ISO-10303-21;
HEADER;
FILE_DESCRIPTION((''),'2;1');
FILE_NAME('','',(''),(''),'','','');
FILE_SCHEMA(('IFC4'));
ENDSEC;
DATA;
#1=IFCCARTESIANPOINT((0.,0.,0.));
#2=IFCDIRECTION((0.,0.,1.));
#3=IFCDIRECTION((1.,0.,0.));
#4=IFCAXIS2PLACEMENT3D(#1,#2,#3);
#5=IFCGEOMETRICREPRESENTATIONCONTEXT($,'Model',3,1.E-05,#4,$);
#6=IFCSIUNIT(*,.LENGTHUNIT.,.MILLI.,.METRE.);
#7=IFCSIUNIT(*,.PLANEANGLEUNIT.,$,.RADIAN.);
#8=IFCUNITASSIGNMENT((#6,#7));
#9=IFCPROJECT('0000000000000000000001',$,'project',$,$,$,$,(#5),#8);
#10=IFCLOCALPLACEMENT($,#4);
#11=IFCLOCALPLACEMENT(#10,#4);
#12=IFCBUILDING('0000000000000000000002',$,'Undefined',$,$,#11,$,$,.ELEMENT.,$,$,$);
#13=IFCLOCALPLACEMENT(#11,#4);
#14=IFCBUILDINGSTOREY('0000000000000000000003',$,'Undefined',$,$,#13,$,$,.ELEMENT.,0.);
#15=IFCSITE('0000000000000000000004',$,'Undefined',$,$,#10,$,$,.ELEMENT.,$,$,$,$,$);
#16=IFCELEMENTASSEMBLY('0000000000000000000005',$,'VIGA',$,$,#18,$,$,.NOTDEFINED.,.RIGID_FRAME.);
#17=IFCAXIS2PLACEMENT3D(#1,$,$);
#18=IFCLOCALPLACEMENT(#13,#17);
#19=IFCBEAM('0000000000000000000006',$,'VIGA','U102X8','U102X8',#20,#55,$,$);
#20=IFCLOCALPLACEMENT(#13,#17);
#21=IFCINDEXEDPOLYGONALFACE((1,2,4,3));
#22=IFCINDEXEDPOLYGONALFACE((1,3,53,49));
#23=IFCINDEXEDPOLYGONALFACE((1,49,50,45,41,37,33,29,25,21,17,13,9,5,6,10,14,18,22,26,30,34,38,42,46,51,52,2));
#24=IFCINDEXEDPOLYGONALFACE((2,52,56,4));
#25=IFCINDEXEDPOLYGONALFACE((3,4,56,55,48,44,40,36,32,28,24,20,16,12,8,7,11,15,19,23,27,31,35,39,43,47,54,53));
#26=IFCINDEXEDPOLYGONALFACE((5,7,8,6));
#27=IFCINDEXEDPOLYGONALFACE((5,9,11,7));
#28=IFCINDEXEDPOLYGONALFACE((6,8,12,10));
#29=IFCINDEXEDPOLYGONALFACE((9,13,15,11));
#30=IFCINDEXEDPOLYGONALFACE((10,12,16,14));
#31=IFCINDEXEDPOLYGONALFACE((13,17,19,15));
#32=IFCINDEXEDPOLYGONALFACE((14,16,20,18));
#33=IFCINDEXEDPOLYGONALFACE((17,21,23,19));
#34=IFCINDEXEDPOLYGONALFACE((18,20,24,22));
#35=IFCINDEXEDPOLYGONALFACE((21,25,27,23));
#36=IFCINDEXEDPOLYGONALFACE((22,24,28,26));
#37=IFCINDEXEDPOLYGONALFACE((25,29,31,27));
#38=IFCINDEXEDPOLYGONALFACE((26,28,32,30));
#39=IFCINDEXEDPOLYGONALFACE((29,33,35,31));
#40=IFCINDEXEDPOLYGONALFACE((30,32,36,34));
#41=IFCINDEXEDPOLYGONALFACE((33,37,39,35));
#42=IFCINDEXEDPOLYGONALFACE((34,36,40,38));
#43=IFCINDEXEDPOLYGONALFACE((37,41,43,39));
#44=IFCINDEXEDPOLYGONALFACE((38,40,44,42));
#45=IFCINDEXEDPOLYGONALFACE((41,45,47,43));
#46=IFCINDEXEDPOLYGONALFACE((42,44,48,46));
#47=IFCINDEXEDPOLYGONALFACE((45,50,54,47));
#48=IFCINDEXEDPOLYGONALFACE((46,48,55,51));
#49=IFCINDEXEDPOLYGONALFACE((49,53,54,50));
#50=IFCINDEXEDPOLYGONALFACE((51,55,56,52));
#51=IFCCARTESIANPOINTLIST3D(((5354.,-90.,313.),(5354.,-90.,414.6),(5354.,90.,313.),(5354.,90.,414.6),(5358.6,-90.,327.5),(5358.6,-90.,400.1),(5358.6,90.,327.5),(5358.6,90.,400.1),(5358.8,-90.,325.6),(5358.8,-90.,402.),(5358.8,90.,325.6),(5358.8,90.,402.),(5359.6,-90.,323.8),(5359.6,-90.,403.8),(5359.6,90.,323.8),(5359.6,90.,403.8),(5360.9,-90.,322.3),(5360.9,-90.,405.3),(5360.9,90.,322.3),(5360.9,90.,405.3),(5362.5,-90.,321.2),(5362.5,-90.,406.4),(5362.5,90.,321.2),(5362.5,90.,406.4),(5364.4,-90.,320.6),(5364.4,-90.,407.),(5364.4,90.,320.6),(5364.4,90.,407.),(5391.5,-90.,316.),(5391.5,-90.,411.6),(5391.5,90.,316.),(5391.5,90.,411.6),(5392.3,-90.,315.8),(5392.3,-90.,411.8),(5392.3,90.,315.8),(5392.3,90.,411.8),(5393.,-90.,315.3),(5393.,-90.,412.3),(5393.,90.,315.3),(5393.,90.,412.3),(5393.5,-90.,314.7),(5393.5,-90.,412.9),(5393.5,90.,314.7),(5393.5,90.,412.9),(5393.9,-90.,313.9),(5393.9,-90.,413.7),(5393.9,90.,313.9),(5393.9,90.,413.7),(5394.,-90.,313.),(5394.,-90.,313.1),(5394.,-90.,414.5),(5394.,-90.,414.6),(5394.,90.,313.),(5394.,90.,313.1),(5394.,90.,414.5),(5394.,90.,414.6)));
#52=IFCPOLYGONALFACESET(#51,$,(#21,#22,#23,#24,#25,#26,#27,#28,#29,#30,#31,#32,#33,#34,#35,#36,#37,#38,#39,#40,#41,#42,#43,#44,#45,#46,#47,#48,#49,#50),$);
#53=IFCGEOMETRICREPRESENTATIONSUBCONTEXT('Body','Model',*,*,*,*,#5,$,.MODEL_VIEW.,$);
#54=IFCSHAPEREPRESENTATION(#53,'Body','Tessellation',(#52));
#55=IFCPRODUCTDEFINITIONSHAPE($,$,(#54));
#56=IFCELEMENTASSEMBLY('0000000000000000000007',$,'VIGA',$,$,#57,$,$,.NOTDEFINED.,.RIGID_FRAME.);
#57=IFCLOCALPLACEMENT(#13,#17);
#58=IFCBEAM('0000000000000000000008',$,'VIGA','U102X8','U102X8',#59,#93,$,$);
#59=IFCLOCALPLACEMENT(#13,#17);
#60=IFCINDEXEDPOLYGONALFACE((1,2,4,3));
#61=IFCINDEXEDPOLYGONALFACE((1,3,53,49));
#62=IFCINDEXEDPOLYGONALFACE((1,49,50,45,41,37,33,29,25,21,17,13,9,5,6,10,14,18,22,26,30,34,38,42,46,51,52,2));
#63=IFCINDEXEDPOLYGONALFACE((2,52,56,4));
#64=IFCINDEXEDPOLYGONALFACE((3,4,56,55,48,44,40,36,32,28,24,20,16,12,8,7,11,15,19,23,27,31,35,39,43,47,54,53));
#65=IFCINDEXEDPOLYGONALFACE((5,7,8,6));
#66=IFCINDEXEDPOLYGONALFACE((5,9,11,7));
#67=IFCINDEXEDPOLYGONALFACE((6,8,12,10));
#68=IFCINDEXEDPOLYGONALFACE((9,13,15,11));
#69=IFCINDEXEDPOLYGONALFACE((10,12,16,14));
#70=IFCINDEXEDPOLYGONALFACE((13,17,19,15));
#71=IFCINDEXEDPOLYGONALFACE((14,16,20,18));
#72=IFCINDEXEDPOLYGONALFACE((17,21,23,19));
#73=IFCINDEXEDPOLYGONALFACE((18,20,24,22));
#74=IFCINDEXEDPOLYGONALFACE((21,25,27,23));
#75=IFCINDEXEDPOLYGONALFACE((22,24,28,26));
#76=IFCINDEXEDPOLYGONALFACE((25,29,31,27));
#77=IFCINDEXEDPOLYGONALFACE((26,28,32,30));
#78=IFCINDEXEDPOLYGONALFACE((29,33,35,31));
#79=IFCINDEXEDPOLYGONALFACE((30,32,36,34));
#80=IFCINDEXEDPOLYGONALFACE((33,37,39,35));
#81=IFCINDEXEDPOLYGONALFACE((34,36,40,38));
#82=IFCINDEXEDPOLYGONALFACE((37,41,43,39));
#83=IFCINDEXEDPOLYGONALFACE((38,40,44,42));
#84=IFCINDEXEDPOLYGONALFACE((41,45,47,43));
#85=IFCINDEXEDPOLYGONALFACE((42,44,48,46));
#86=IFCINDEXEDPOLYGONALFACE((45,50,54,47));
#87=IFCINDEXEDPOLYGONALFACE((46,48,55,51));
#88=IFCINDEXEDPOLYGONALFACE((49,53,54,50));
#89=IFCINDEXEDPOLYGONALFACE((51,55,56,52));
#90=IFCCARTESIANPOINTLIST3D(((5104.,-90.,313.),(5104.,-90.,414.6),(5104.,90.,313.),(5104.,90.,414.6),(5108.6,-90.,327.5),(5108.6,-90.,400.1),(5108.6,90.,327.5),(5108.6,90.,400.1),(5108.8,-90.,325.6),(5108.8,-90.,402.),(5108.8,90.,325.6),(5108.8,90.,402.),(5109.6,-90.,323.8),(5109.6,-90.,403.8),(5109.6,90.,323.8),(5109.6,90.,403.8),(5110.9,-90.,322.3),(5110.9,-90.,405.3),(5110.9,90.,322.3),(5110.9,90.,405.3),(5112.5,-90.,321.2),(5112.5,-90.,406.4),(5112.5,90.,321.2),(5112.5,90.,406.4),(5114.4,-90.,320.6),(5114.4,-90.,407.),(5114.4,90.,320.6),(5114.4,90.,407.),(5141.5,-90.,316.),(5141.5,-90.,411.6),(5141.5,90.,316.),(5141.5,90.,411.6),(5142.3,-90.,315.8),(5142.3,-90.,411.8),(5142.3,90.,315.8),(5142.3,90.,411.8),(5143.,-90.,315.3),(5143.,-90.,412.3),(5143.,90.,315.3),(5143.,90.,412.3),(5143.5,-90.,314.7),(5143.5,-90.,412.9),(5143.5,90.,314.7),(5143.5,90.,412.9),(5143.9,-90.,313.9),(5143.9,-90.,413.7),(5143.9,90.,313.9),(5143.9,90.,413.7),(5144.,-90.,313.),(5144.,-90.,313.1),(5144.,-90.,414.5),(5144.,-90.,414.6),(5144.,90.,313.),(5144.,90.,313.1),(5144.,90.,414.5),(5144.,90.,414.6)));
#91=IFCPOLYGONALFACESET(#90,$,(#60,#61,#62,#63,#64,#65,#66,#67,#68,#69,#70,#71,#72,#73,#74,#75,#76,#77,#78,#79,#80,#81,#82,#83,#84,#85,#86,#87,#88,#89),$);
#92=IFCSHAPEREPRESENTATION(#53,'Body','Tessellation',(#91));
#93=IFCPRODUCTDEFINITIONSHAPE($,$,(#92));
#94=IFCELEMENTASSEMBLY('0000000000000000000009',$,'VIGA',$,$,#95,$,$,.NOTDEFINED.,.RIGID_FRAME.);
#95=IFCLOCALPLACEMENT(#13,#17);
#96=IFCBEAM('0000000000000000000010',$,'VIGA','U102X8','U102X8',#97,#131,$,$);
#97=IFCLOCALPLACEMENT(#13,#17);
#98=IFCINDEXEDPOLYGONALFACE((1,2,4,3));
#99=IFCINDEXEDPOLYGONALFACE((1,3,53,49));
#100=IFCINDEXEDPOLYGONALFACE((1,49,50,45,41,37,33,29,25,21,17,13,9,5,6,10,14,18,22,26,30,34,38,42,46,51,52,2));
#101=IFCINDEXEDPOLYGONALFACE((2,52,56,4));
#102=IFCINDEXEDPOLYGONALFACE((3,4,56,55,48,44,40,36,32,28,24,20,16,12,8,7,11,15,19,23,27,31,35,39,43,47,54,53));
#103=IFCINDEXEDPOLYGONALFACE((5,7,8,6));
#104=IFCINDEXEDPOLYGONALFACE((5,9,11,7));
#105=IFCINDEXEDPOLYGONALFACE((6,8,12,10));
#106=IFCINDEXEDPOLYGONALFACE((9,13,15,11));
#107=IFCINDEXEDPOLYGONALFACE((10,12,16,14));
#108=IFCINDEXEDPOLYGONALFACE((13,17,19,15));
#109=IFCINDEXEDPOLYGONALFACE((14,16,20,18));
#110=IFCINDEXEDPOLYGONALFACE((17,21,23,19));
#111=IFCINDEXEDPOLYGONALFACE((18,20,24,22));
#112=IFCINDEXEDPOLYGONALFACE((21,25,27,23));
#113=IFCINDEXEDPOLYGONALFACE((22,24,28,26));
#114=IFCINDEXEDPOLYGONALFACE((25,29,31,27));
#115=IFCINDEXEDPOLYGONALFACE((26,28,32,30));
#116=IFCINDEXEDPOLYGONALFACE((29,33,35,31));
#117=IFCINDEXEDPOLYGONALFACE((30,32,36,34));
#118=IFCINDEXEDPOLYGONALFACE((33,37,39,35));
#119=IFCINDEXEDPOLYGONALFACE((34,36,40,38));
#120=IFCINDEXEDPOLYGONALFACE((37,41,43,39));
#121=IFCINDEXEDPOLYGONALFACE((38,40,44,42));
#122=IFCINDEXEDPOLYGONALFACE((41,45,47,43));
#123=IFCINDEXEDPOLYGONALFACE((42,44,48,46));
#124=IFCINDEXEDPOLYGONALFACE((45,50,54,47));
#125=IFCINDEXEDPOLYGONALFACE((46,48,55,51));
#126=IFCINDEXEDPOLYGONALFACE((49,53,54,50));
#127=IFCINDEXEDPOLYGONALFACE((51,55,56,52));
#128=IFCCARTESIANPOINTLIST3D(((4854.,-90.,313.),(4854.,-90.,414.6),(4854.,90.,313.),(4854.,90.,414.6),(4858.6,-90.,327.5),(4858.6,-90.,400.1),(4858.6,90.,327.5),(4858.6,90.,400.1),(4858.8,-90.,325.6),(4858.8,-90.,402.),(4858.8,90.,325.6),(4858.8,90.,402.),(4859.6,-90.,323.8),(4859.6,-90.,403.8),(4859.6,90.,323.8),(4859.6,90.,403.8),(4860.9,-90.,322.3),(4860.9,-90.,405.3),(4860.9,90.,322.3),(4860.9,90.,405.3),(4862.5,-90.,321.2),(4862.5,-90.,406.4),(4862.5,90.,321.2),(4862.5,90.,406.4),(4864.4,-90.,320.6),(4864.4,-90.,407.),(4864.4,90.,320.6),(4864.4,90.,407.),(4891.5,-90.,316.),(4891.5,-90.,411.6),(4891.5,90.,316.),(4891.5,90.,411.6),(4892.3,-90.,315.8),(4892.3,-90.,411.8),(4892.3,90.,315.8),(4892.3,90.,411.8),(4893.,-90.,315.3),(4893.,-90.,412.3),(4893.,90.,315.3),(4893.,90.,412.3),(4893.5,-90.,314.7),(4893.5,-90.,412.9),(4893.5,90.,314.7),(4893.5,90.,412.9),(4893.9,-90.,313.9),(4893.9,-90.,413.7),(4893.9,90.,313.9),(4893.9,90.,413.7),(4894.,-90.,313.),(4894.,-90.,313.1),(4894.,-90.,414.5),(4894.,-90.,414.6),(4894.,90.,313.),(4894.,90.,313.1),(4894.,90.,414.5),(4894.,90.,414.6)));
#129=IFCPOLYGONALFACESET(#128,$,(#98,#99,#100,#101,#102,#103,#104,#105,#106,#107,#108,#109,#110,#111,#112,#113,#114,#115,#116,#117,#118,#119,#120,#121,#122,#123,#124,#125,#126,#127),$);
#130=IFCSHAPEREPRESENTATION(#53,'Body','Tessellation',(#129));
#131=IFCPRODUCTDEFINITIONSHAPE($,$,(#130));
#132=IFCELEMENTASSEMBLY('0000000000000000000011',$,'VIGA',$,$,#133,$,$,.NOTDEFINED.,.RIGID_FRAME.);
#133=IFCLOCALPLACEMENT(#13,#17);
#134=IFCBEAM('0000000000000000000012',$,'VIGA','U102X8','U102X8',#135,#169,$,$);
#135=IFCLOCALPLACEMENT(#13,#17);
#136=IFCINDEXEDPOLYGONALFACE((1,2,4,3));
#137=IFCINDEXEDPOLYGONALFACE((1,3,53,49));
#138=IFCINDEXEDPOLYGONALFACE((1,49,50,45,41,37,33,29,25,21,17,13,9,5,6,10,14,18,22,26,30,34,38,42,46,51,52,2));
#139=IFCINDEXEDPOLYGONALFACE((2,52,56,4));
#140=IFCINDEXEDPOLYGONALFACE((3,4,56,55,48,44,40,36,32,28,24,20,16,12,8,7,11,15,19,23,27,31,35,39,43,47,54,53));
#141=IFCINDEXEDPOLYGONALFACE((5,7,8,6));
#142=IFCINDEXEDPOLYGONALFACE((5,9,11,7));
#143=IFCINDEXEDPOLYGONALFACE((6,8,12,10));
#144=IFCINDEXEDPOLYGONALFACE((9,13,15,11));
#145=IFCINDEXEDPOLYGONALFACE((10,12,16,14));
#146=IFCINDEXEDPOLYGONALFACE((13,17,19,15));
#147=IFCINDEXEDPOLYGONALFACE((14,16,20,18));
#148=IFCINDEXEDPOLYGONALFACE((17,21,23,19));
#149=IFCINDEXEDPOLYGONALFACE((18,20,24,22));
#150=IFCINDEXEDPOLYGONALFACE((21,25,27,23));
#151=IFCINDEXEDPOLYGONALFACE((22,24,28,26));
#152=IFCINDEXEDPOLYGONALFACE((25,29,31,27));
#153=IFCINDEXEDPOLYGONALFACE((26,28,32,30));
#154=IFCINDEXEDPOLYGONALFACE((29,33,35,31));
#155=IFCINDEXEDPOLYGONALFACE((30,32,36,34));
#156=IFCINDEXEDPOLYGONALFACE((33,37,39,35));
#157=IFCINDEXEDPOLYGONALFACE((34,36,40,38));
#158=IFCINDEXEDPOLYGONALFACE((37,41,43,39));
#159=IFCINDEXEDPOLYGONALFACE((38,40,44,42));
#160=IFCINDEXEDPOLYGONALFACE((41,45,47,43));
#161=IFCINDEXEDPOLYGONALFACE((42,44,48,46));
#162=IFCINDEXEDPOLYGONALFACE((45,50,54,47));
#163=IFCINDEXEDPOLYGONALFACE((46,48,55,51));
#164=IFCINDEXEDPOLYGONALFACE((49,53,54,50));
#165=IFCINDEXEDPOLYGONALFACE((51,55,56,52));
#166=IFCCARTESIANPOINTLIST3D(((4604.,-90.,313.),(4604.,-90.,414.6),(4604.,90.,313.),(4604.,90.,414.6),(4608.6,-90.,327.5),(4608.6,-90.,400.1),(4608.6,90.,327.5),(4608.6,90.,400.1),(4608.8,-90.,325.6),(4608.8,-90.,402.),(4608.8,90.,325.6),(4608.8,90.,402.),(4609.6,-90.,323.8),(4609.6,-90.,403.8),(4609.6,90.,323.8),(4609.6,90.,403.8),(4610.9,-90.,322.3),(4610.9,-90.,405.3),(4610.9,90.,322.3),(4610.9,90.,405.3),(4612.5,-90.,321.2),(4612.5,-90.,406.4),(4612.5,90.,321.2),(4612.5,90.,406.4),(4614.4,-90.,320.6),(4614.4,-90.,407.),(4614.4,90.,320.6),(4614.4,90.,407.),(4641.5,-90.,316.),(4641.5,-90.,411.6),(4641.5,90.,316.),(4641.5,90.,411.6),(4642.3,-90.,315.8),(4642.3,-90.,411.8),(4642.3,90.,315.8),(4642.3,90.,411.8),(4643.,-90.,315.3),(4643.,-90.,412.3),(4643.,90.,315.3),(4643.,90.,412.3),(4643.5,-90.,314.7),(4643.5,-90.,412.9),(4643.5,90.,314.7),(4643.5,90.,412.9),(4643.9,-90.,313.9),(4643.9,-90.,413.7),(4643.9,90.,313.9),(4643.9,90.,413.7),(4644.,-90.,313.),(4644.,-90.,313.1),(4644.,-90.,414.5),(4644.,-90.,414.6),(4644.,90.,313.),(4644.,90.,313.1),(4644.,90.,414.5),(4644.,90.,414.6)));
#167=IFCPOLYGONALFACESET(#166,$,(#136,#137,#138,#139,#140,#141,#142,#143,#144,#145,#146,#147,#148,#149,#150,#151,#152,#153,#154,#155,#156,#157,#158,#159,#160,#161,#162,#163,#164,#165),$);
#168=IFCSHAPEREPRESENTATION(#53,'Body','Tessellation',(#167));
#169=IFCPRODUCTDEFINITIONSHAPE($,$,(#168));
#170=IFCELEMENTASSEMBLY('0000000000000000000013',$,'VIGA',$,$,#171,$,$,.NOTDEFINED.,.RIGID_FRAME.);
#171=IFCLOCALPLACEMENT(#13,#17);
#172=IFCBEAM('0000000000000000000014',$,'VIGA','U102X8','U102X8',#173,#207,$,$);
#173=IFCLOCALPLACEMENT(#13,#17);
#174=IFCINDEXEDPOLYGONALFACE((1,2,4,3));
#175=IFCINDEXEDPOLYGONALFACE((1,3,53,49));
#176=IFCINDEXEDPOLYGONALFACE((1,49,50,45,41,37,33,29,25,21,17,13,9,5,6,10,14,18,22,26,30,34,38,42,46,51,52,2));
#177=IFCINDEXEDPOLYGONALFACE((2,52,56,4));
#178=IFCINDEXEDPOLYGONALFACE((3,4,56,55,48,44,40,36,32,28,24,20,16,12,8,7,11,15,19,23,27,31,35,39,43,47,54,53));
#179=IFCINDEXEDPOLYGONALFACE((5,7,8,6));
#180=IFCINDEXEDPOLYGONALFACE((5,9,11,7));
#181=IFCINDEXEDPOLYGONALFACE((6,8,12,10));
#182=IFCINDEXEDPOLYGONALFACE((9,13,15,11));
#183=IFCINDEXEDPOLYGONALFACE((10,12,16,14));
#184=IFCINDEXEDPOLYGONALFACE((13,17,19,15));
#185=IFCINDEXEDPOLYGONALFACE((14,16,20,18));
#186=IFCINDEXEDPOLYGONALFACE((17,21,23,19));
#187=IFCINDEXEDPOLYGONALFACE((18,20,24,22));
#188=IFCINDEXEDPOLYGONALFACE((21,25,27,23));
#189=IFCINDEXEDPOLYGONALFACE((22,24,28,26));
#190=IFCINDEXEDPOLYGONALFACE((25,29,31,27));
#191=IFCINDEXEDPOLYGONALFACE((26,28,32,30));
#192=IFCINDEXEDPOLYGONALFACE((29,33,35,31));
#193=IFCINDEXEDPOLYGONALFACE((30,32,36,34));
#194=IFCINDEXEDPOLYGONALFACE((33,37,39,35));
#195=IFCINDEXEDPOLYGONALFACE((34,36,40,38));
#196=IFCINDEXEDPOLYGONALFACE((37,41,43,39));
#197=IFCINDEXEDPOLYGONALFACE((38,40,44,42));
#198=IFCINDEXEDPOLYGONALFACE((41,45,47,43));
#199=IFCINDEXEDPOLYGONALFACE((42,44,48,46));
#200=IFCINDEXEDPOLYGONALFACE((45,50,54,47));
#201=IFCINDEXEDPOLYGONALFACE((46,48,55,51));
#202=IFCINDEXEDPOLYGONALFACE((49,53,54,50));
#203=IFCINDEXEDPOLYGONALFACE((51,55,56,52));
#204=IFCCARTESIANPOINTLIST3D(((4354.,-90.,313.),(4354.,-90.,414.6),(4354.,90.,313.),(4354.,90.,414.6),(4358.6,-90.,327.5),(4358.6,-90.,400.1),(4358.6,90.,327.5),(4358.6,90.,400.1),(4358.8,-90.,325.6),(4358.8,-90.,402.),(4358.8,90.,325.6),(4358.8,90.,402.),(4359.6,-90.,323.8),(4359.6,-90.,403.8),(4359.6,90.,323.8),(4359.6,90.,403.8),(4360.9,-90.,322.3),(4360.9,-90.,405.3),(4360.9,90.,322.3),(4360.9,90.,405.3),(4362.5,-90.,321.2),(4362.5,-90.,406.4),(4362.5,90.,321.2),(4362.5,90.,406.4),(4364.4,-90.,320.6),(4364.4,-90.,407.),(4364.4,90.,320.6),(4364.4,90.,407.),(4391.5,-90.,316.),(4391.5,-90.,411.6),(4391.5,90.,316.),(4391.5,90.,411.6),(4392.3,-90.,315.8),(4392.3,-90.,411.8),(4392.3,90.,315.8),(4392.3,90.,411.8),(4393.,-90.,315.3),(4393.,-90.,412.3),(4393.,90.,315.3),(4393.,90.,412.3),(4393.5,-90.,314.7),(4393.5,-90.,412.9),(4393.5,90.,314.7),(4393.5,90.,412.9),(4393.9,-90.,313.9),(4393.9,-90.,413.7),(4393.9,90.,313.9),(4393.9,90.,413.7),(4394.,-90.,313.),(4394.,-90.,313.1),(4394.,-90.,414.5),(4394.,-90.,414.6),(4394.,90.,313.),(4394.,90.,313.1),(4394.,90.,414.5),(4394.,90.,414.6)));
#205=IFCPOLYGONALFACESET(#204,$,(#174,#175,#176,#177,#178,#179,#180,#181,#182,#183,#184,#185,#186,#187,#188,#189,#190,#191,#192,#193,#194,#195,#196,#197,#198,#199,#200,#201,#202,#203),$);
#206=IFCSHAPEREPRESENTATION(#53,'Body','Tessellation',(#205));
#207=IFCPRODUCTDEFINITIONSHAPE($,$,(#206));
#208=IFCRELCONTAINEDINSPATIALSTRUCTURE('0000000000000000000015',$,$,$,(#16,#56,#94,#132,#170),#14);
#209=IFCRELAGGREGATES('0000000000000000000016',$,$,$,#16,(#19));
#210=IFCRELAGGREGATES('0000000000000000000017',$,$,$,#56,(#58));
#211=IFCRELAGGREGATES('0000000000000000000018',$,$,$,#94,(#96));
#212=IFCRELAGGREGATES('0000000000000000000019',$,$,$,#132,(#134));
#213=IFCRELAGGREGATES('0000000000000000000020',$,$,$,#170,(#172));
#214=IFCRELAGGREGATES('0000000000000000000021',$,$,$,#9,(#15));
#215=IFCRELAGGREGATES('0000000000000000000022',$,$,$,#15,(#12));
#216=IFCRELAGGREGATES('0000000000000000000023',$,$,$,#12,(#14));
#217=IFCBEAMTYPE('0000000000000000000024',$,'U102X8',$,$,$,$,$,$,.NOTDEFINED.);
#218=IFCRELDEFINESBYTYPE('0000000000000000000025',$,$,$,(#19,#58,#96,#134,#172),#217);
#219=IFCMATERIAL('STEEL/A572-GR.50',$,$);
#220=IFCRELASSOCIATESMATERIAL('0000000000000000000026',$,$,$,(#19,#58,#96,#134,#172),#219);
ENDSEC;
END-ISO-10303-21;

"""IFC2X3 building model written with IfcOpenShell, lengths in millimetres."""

from ifc_helpers import new_model, si_unit, frame, origin_with_axes, origin_2d_with_axis, place, context, subcontext, project, spatial, u_section, extrude, material, type_object, element, aggregate, save


model = new_model("IFC2X3")

# Units and contexts
model_context = context("Model", 3, precision=1e-05, world=origin_with_axes())
body_context = subcontext(model_context, "Body", "Model", "MODEL_VIEW")
ifc_project = project(units=[si_unit("LENGTHUNIT", "METRE", prefix="MILLI"), si_unit("PLANEANGLEUNIT", "RADIAN")], contexts=[model_context])

# Site, building, storey
site_placement = place(None, origin_with_axes())
site = spatial("IfcSite", under=ifc_project, at=site_placement, Name="Undefined", CompositionType="ELEMENT")
building_placement = place(site_placement, origin_with_axes())
building = spatial("IfcBuilding", under=site, at=building_placement, Name="Undefined", CompositionType="ELEMENT")
storey_placement = place(building_placement, origin_with_axes())
storey = spatial("IfcBuildingStorey", under=building, at=storey_placement, Name="Undefined", CompositionType="ELEMENT", Elevation=0.0)

# Element assemblies, beams
ifc_material = material(Name="STEEL/A572-GR.50")
beam_type = type_object("IfcBeamType", Name="U102X8", PredefinedType="NOTDEFINED")
assembly_1_placement = place(storey_placement, origin_with_axes())
assembly_1 = element("IfcElementAssembly", 1, at=assembly_1_placement, inside=storey, Name="VIGA", AssemblyPlace="NOTDEFINED", PredefinedType="RIGID_FRAME")
beam_1_placement = place(assembly_1_placement, frame((5374.0, -90.0, 363.8), z_axis=(0.0, 0.0, 1.0), x_axis=(0.0, 1.0, 0.0)))
beam_1 = element("IfcBeam", 2, at=beam_1_placement, type_object=beam_type, material=ifc_material, Name="VIGA", Description="U102X8", ObjectType="U102X8", context=body_context, shape_type="SweptSolid", body=[
    extrude(u_section(Depth=101.6, FlangeWidth=40.0, WebThickness=4.6, FlangeThickness=6.0, FilletRadius=7.0, EdgeRadius=3.0, FlangeSlope=0.16839, at=origin_2d_with_axis()), frame((180.0, 0.0, 0.0), z_axis=(-1.0, 0.0, 0.0), x_axis=(0.0, -1.0, 0.0)), (0.0, 0.0, 1.0), 180.0),
])
aggregate(assembly_1, [beam_1])
assembly_2_placement = place(storey_placement, origin_with_axes())
assembly_2 = element("IfcElementAssembly", 3, at=assembly_2_placement, inside=storey, Name="VIGA", AssemblyPlace="NOTDEFINED", PredefinedType="RIGID_FRAME")
beam_2_placement = place(assembly_2_placement, frame((5124.0, -90.0, 363.8), z_axis=(0.0, 0.0, 1.0), x_axis=(0.0, 1.0, 0.0)))
beam_2 = element("IfcBeam", 4, at=beam_2_placement, type_object=beam_type, material=ifc_material, Name="VIGA", Description="U102X8", ObjectType="U102X8", context=body_context, shape_type="SweptSolid", body=[
    extrude(u_section(Depth=101.6, FlangeWidth=40.0, WebThickness=4.6, FlangeThickness=6.0, FilletRadius=7.0, EdgeRadius=3.0, FlangeSlope=0.16839, at=origin_2d_with_axis()), frame((180.0, 0.0, 0.0), z_axis=(-1.0, 0.0, 0.0), x_axis=(0.0, -1.0, 0.0)), (0.0, 0.0, 1.0), 180.0),
])
aggregate(assembly_2, [beam_2])
assembly_3_placement = place(storey_placement, origin_with_axes())
assembly_3 = element("IfcElementAssembly", 5, at=assembly_3_placement, inside=storey, Name="VIGA", AssemblyPlace="NOTDEFINED", PredefinedType="RIGID_FRAME")
beam_3_placement = place(assembly_3_placement, frame((4874.0, -90.0, 363.8), z_axis=(0.0, 0.0, 1.0), x_axis=(0.0, 1.0, 0.0)))
beam_3 = element("IfcBeam", 6, at=beam_3_placement, type_object=beam_type, material=ifc_material, Name="VIGA", Description="U102X8", ObjectType="U102X8", context=body_context, shape_type="SweptSolid", body=[
    extrude(u_section(Depth=101.6, FlangeWidth=40.0, WebThickness=4.6, FlangeThickness=6.0, FilletRadius=7.0, EdgeRadius=3.0, FlangeSlope=0.16839, at=origin_2d_with_axis()), frame((180.0, 0.0, 0.0), z_axis=(-1.0, 0.0, 0.0), x_axis=(0.0, -1.0, 0.0)), (0.0, 0.0, 1.0), 180.0),
])
aggregate(assembly_3, [beam_3])
assembly_4_placement = place(storey_placement, origin_with_axes())
assembly_4 = element("IfcElementAssembly", 7, at=assembly_4_placement, inside=storey, Name="VIGA", AssemblyPlace="NOTDEFINED", PredefinedType="RIGID_FRAME")
beam_4_placement = place(assembly_4_placement, frame((4624.0, -90.0, 363.8), z_axis=(0.0, 0.0, 1.0), x_axis=(0.0, 1.0, 0.0)))
beam_4 = element("IfcBeam", 8, at=beam_4_placement, type_object=beam_type, material=ifc_material, Name="VIGA", Description="U102X8", ObjectType="U102X8", context=body_context, shape_type="SweptSolid", body=[
    extrude(u_section(Depth=101.6, FlangeWidth=40.0, WebThickness=4.6, FlangeThickness=6.0, FilletRadius=7.0, EdgeRadius=3.0, FlangeSlope=0.16839, at=origin_2d_with_axis()), frame((180.0, 0.0, 0.0), z_axis=(-1.0, 0.0, 0.0), x_axis=(0.0, -1.0, 0.0)), (0.0, 0.0, 1.0), 180.0),
])
aggregate(assembly_4, [beam_4])
assembly_5_placement = place(storey_placement, origin_with_axes())
assembly_5 = element("IfcElementAssembly", 9, at=assembly_5_placement, inside=storey, Name="VIGA", AssemblyPlace="NOTDEFINED", PredefinedType="RIGID_FRAME")
beam_5_placement = place(assembly_5_placement, frame((4374.0, -90.0, 363.8), z_axis=(0.0, 0.0, 1.0), x_axis=(0.0, 1.0, 0.0)))
beam_5 = element("IfcBeam", 10, at=beam_5_placement, type_object=beam_type, material=ifc_material, Name="VIGA", Description="U102X8", ObjectType="U102X8", context=body_context, shape_type="SweptSolid", body=[
    extrude(u_section(Depth=101.6, FlangeWidth=40.0, WebThickness=4.6, FlangeThickness=6.0, FilletRadius=7.0, EdgeRadius=3.0, FlangeSlope=0.16839, at=origin_2d_with_axis()), frame((180.0, 0.0, 0.0), z_axis=(-1.0, 0.0, 0.0), x_axis=(0.0, -1.0, 0.0)), (0.0, 0.0, 1.0), 180.0),
])
aggregate(assembly_5, [beam_5])

save(model, "model.ifc")
